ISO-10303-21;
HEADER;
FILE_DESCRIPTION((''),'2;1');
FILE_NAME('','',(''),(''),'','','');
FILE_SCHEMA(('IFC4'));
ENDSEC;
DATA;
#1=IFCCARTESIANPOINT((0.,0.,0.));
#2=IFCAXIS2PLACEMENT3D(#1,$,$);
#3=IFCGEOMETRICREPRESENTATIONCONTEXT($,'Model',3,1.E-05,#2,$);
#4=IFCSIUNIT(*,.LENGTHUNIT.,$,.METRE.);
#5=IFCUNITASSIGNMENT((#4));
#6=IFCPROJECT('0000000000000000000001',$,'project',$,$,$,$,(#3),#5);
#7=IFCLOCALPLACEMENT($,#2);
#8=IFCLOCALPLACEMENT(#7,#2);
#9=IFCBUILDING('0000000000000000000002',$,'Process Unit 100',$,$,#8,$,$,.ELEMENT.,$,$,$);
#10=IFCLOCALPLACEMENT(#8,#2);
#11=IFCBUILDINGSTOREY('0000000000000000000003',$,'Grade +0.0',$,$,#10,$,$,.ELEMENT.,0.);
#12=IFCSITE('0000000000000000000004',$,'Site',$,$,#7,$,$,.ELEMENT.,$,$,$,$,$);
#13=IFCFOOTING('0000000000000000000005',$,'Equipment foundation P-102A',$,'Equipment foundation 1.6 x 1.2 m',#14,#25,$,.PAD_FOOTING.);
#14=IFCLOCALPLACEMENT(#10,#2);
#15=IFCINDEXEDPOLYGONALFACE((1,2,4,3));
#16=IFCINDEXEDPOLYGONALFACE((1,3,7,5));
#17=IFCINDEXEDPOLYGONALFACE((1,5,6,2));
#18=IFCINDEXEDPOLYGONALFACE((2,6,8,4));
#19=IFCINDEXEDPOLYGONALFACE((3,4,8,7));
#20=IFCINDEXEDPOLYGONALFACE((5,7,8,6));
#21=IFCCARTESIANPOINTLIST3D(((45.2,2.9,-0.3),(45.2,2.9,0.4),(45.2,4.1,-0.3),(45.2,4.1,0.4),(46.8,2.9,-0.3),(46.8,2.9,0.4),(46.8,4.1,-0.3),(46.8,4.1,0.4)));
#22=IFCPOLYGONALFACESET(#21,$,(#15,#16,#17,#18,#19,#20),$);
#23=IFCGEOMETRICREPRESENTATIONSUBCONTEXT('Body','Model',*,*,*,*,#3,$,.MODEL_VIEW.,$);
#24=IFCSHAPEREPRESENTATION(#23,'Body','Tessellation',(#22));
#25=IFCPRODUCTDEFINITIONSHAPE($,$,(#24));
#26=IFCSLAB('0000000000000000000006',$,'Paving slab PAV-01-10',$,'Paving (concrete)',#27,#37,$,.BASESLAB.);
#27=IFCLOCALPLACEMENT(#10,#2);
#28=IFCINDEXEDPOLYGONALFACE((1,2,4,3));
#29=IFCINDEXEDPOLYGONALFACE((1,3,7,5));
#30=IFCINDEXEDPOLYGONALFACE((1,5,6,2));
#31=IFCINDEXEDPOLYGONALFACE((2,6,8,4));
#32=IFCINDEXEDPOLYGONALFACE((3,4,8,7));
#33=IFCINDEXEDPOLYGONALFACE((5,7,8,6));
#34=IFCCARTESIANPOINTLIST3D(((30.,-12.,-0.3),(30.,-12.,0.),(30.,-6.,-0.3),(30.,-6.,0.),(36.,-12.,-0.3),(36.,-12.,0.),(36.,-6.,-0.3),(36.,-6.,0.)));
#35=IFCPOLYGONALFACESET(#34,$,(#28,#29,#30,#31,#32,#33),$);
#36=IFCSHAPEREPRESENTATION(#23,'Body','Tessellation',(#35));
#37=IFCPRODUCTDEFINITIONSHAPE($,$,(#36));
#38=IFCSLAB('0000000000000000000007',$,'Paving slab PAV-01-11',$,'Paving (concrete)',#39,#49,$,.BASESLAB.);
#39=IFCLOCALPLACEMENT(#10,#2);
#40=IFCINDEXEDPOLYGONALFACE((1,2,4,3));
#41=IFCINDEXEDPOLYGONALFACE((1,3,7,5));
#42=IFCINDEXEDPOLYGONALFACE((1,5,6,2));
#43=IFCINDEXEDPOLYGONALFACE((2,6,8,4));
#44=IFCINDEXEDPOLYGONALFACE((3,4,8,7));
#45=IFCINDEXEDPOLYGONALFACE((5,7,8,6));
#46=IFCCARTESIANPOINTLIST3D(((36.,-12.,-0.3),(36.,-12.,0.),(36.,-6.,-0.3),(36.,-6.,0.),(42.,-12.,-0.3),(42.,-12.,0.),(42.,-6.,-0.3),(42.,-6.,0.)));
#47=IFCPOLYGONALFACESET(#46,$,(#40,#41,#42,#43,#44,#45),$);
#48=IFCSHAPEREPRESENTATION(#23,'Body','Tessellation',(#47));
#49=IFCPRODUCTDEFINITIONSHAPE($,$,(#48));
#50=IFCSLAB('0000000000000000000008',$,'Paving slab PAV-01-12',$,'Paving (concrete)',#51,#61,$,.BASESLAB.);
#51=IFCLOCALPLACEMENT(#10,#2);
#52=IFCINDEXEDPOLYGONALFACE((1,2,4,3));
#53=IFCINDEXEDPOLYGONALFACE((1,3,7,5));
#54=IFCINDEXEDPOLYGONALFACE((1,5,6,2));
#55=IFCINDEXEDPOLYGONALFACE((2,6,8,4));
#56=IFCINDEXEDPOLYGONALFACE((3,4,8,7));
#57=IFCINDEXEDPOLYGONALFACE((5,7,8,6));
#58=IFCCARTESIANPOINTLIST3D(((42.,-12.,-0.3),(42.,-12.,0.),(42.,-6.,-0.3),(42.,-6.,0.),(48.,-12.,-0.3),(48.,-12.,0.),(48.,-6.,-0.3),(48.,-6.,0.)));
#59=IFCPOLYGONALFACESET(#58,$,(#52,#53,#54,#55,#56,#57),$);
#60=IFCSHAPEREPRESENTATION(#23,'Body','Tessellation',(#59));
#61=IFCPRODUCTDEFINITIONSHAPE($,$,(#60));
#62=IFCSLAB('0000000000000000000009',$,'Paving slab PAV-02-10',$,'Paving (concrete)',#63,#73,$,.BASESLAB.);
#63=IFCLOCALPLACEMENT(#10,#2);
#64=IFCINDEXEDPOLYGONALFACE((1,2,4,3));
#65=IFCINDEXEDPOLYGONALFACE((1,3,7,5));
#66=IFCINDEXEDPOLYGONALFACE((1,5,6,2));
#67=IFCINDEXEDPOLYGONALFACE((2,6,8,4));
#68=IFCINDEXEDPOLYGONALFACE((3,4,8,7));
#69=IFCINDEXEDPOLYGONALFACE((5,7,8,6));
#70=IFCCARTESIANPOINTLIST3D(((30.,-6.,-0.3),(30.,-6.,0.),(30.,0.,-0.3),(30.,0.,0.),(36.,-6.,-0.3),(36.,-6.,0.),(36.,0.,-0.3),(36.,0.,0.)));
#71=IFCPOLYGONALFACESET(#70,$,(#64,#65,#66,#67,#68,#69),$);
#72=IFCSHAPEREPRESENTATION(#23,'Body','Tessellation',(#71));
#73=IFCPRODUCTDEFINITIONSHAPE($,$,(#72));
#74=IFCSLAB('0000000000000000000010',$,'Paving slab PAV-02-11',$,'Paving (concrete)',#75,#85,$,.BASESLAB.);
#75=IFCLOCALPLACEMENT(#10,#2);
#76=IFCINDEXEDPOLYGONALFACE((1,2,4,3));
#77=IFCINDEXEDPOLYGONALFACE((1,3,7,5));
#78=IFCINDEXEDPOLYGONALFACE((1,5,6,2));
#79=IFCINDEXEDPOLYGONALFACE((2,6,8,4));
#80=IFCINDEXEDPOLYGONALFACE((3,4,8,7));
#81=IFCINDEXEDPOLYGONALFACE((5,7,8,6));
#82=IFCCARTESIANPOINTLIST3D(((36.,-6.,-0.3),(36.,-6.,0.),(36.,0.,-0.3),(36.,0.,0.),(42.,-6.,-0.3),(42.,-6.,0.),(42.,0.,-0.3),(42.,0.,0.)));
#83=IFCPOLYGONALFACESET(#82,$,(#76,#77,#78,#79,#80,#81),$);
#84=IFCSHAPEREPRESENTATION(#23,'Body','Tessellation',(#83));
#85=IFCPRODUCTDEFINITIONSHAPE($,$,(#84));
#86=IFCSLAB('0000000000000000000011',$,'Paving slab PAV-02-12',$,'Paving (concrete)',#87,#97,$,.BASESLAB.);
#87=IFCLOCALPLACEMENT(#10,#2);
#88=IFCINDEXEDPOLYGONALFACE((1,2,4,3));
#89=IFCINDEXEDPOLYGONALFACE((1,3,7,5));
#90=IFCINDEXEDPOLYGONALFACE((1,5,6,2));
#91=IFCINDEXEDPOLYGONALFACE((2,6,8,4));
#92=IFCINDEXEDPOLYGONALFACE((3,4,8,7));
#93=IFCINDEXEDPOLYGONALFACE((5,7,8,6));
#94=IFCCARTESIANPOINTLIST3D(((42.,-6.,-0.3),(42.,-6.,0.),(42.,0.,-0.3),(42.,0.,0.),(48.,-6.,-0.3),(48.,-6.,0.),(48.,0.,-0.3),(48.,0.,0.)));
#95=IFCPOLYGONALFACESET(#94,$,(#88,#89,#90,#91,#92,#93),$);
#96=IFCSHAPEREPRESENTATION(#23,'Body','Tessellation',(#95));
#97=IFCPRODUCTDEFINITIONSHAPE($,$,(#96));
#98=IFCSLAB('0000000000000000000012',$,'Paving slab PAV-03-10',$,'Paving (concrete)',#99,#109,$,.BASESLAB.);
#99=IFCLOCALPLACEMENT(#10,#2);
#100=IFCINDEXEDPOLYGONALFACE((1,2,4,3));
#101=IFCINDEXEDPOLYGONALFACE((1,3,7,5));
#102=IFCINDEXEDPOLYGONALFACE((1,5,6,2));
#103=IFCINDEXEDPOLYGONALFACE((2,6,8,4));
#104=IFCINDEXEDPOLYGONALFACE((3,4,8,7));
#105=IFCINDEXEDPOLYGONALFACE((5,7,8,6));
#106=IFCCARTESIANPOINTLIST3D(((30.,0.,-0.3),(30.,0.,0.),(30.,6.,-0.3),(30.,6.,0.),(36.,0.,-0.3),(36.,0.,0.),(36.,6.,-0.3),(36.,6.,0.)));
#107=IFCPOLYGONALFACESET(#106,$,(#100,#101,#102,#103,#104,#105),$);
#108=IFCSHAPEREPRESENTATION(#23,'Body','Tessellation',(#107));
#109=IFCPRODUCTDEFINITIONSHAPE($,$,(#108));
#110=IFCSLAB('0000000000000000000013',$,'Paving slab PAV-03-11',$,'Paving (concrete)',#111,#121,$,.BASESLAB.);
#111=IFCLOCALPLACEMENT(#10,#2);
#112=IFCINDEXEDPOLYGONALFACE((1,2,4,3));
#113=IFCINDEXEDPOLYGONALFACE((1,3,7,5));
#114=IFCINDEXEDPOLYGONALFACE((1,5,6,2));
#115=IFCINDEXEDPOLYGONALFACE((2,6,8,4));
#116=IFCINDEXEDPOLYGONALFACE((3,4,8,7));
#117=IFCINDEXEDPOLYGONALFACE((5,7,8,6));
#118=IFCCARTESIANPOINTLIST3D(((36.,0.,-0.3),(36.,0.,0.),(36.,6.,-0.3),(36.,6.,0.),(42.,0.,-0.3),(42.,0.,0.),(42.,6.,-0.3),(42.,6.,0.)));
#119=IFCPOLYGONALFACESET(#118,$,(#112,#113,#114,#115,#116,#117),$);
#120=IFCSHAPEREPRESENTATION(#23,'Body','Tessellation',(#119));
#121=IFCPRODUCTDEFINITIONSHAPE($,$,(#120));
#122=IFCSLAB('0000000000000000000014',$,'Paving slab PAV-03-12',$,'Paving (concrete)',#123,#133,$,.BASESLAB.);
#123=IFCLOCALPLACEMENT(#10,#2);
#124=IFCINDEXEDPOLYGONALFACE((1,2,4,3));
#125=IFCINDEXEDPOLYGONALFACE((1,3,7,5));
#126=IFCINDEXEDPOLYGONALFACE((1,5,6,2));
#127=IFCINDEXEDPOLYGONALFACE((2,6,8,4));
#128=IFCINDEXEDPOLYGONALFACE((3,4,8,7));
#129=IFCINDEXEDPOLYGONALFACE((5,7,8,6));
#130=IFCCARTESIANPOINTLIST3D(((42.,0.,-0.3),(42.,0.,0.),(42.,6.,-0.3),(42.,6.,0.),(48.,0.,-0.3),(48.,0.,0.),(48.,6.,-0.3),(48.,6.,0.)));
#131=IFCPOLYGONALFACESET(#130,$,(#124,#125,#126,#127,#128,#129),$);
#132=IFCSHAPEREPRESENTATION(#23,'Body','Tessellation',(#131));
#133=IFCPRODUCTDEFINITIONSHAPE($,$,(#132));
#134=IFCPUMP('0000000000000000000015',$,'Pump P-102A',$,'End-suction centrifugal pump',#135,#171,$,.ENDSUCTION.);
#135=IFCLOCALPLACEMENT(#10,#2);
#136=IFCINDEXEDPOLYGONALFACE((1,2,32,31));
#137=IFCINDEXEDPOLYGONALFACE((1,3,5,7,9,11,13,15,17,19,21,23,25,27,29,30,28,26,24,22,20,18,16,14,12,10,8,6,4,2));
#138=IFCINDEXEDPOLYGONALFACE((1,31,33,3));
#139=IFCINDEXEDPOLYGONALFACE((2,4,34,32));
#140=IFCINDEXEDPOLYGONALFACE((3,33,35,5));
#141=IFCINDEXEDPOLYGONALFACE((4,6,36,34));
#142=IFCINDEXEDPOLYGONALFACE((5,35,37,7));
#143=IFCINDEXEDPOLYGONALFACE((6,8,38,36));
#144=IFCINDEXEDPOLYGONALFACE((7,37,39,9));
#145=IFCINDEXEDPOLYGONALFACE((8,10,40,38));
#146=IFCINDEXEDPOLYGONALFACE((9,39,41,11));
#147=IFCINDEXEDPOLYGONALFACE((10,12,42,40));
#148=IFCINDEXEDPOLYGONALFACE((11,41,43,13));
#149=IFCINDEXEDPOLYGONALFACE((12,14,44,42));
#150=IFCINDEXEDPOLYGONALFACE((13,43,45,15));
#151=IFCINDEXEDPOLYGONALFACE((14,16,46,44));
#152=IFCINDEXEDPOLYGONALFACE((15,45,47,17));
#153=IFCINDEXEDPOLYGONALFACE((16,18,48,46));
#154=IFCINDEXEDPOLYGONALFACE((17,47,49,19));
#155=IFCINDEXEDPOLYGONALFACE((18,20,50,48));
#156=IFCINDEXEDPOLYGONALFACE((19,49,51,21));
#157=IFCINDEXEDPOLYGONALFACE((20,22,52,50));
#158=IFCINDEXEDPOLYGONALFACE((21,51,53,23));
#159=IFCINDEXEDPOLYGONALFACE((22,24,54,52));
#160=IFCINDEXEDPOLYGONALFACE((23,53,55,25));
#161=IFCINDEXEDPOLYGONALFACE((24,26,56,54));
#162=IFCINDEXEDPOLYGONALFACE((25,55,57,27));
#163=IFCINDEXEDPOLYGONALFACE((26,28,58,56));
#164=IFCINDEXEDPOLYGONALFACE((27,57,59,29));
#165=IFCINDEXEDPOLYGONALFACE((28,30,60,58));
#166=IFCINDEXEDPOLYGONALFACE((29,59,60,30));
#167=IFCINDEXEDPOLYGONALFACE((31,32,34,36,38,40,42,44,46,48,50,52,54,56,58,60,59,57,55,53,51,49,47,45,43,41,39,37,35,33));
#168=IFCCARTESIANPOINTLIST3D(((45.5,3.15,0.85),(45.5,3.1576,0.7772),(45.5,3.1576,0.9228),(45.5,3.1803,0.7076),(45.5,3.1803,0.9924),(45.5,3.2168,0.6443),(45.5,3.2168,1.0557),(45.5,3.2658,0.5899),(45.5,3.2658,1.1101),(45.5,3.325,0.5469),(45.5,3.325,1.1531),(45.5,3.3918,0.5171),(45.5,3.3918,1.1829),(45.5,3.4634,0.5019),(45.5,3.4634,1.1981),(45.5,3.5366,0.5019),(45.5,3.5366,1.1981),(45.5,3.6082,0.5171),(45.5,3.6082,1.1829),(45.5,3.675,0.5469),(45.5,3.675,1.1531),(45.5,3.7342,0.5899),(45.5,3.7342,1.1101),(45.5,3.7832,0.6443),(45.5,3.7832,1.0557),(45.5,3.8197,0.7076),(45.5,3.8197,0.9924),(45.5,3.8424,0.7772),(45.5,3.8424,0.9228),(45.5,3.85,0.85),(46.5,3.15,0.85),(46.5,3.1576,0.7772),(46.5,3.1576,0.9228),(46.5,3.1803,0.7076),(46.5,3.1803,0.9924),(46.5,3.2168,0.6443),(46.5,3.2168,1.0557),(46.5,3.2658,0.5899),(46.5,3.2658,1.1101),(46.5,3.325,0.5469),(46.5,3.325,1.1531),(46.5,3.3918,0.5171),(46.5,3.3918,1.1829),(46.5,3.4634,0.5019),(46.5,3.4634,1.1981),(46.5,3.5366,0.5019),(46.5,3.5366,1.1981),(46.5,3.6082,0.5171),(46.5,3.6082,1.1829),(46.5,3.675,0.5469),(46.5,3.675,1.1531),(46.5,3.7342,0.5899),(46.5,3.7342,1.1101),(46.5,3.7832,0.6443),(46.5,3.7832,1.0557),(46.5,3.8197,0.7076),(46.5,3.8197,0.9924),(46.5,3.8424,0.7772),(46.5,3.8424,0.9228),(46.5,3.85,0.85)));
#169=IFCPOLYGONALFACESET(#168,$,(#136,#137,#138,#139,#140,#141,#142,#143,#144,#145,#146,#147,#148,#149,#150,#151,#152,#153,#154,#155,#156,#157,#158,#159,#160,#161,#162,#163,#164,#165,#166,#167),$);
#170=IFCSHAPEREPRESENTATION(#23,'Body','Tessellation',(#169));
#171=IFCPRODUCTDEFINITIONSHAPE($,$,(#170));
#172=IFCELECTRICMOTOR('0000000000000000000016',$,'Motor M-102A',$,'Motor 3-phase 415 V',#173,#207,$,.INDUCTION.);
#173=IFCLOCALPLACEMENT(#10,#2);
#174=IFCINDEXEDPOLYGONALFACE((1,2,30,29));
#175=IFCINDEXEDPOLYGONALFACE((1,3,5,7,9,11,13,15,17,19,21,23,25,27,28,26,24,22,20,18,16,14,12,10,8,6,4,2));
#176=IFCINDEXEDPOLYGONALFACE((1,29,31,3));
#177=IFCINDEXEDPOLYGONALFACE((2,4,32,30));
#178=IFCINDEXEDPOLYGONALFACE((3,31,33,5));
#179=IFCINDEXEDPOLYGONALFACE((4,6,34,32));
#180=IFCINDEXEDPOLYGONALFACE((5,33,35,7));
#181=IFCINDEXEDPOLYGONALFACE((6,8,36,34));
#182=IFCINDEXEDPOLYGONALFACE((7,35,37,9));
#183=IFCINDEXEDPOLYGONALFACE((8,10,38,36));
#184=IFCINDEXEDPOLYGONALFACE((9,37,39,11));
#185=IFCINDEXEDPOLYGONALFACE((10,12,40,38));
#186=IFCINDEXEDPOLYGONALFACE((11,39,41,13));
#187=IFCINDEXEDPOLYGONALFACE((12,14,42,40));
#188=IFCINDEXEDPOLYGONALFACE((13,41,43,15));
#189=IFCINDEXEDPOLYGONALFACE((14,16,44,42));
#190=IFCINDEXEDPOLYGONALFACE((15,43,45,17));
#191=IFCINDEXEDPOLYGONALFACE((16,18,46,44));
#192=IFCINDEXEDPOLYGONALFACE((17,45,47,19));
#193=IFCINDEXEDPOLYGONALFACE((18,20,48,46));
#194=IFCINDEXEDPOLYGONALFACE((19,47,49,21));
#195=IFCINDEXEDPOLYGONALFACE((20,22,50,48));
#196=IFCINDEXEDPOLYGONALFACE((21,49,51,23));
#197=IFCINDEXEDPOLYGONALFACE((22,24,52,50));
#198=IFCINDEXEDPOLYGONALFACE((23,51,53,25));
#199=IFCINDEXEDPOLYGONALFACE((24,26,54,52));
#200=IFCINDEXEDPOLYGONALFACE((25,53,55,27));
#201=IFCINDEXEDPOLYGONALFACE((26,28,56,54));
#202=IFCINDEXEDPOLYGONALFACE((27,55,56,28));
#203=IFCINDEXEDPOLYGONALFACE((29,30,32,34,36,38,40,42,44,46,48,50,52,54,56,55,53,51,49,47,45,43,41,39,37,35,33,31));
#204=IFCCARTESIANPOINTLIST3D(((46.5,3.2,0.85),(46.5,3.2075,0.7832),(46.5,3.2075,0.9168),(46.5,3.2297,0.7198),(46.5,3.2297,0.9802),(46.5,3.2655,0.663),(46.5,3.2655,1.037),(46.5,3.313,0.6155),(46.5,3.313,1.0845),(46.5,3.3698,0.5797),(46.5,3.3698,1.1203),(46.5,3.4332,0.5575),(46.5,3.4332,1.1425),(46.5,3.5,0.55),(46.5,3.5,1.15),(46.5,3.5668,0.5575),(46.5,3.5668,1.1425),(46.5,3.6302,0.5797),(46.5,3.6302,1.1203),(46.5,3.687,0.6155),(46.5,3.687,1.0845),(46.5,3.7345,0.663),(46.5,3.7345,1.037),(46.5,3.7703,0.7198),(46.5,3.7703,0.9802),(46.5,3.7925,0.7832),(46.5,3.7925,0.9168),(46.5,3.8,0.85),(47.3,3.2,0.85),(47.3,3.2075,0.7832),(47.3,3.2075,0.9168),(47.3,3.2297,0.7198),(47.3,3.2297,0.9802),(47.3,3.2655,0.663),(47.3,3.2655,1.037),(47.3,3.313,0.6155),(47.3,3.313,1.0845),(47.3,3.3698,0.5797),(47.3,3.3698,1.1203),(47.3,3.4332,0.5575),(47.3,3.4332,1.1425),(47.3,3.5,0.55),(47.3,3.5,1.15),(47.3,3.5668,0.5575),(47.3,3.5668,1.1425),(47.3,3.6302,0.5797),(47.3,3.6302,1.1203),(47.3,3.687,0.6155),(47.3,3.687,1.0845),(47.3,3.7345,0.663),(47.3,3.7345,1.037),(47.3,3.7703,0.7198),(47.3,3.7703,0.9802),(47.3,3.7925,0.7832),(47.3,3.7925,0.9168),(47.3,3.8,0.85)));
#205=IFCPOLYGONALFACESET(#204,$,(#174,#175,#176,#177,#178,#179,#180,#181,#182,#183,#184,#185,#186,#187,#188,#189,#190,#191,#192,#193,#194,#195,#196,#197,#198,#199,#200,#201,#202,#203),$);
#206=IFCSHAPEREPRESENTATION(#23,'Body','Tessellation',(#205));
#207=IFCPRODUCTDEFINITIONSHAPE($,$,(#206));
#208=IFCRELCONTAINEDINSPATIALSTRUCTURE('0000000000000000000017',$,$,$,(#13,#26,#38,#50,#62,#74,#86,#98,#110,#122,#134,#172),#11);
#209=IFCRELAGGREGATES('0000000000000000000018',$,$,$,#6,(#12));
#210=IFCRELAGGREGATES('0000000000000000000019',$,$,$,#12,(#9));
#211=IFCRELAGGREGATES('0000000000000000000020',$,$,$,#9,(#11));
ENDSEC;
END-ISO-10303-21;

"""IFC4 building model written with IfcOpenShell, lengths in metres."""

from ifc_helpers import new_model, si_unit, frame, origin, place, context, subcontext, project, spatial, rectangle, circle, extrude, element, save


model = new_model("IFC4")

# Units and contexts
model_context = context("Model", 3, precision=1e-05, world=origin())
body_context = subcontext(model_context, "Body", "Model", "MODEL_VIEW")
ifc_project = project(units=[si_unit("LENGTHUNIT", "METRE")], contexts=[model_context])

# Site, building, storey
site_placement = place(None, origin())
site = spatial("IfcSite", under=ifc_project, at=site_placement, Name="Site", CompositionType="ELEMENT")
building_placement = place(site_placement, origin())
building = spatial("IfcBuilding", under=site, at=building_placement, Name="Process Unit 100", CompositionType="ELEMENT")
storey_placement = place(building_placement, origin())
storey = spatial("IfcBuildingStorey", under=building, at=storey_placement, Name="Grade +0.0", CompositionType="ELEMENT", Elevation=0.0)

# Footing
footing_placement = place(storey_placement, frame((46.0, 3.5, -0.3), z_axis=(0.0, 0.0, 1.0), x_axis=(1.0, 0.0, 0.0)))
element("IfcFooting", 1, at=footing_placement, inside=storey, Name="Equipment foundation P-102A", ObjectType="Equipment foundation 1.6 x 1.2 m", PredefinedType="PAD_FOOTING", context=body_context, shape_type="SweptSolid", body=[
    extrude(rectangle(XDim=1.6, YDim=1.2), origin(), (0.0, 0.0, 1.0), 0.7),
])

# Slabs
for number, where, z_axis, x_axis, name in (
    (2, (33.0, -9.0, -0.3), (0.0, 0.0, 1.0), (1.0, 0.0, 0.0), "Paving slab PAV-01-10"),
    (3, (39.0, -9.0, -0.3), (0.0, 0.0, 1.0), (1.0, 0.0, 0.0), "Paving slab PAV-01-11"),
    (4, (45.0, -9.0, -0.3), (0.0, 0.0, 1.0), (1.0, 0.0, 0.0), "Paving slab PAV-01-12"),
    (5, (33.0, -3.0, -0.3), (0.0, 0.0, 1.0), (1.0, 0.0, 0.0), "Paving slab PAV-02-10"),
    (6, (39.0, -3.0, -0.3), (0.0, 0.0, 1.0), (1.0, 0.0, 0.0), "Paving slab PAV-02-11"),
    (7, (45.0, -3.0, -0.3), (0.0, 0.0, 1.0), (1.0, 0.0, 0.0), "Paving slab PAV-02-12"),
    (8, (33.0, 3.0, -0.3), (0.0, 0.0, 1.0), (1.0, 0.0, 0.0), "Paving slab PAV-03-10"),
    (9, (39.0, 3.0, -0.3), (0.0, 0.0, 1.0), (1.0, 0.0, 0.0), "Paving slab PAV-03-11"),
    (10, (45.0, 3.0, -0.3), (0.0, 0.0, 1.0), (1.0, 0.0, 0.0), "Paving slab PAV-03-12"),
):
    element("IfcSlab", number, at=place(storey_placement, frame(where, z_axis=z_axis, x_axis=x_axis)), inside=storey, Name=name, ObjectType="Paving (concrete)", PredefinedType="BASESLAB", context=body_context, shape_type="SweptSolid", body=[
        extrude(rectangle(XDim=6.0, YDim=6.0), origin(), (0.0, 0.0, 1.0), 0.3),
    ])

# Pump
pump_1_placement = place(storey_placement, frame((45.5, 3.5, 0.85), z_axis=(1.0, 0.0, 0.0), x_axis=(0.0, 1.0, 0.0)))
element("IfcPump", 11, at=pump_1_placement, inside=storey, Name="Pump P-102A", ObjectType="End-suction centrifugal pump", PredefinedType="ENDSUCTION", context=body_context, shape_type="SweptSolid", body=[
    extrude(circle(Radius=0.35), origin(), (0.0, 0.0, 1.0), 1.0),
])

# Electric motor
electric_motor_placement = place(storey_placement, frame((46.5, 3.5, 0.85), z_axis=(1.0, 0.0, 0.0), x_axis=(0.0, 1.0, 0.0)))
element("IfcElectricMotor", 12, at=electric_motor_placement, inside=storey, Name="Motor M-102A", ObjectType="Motor 3-phase 415 V", PredefinedType="INDUCTION", context=body_context, shape_type="SweptSolid", body=[
    extrude(circle(Radius=0.3), origin(), (0.0, 0.0, 1.0), 0.8),
])

save(model, "model.ifc")
